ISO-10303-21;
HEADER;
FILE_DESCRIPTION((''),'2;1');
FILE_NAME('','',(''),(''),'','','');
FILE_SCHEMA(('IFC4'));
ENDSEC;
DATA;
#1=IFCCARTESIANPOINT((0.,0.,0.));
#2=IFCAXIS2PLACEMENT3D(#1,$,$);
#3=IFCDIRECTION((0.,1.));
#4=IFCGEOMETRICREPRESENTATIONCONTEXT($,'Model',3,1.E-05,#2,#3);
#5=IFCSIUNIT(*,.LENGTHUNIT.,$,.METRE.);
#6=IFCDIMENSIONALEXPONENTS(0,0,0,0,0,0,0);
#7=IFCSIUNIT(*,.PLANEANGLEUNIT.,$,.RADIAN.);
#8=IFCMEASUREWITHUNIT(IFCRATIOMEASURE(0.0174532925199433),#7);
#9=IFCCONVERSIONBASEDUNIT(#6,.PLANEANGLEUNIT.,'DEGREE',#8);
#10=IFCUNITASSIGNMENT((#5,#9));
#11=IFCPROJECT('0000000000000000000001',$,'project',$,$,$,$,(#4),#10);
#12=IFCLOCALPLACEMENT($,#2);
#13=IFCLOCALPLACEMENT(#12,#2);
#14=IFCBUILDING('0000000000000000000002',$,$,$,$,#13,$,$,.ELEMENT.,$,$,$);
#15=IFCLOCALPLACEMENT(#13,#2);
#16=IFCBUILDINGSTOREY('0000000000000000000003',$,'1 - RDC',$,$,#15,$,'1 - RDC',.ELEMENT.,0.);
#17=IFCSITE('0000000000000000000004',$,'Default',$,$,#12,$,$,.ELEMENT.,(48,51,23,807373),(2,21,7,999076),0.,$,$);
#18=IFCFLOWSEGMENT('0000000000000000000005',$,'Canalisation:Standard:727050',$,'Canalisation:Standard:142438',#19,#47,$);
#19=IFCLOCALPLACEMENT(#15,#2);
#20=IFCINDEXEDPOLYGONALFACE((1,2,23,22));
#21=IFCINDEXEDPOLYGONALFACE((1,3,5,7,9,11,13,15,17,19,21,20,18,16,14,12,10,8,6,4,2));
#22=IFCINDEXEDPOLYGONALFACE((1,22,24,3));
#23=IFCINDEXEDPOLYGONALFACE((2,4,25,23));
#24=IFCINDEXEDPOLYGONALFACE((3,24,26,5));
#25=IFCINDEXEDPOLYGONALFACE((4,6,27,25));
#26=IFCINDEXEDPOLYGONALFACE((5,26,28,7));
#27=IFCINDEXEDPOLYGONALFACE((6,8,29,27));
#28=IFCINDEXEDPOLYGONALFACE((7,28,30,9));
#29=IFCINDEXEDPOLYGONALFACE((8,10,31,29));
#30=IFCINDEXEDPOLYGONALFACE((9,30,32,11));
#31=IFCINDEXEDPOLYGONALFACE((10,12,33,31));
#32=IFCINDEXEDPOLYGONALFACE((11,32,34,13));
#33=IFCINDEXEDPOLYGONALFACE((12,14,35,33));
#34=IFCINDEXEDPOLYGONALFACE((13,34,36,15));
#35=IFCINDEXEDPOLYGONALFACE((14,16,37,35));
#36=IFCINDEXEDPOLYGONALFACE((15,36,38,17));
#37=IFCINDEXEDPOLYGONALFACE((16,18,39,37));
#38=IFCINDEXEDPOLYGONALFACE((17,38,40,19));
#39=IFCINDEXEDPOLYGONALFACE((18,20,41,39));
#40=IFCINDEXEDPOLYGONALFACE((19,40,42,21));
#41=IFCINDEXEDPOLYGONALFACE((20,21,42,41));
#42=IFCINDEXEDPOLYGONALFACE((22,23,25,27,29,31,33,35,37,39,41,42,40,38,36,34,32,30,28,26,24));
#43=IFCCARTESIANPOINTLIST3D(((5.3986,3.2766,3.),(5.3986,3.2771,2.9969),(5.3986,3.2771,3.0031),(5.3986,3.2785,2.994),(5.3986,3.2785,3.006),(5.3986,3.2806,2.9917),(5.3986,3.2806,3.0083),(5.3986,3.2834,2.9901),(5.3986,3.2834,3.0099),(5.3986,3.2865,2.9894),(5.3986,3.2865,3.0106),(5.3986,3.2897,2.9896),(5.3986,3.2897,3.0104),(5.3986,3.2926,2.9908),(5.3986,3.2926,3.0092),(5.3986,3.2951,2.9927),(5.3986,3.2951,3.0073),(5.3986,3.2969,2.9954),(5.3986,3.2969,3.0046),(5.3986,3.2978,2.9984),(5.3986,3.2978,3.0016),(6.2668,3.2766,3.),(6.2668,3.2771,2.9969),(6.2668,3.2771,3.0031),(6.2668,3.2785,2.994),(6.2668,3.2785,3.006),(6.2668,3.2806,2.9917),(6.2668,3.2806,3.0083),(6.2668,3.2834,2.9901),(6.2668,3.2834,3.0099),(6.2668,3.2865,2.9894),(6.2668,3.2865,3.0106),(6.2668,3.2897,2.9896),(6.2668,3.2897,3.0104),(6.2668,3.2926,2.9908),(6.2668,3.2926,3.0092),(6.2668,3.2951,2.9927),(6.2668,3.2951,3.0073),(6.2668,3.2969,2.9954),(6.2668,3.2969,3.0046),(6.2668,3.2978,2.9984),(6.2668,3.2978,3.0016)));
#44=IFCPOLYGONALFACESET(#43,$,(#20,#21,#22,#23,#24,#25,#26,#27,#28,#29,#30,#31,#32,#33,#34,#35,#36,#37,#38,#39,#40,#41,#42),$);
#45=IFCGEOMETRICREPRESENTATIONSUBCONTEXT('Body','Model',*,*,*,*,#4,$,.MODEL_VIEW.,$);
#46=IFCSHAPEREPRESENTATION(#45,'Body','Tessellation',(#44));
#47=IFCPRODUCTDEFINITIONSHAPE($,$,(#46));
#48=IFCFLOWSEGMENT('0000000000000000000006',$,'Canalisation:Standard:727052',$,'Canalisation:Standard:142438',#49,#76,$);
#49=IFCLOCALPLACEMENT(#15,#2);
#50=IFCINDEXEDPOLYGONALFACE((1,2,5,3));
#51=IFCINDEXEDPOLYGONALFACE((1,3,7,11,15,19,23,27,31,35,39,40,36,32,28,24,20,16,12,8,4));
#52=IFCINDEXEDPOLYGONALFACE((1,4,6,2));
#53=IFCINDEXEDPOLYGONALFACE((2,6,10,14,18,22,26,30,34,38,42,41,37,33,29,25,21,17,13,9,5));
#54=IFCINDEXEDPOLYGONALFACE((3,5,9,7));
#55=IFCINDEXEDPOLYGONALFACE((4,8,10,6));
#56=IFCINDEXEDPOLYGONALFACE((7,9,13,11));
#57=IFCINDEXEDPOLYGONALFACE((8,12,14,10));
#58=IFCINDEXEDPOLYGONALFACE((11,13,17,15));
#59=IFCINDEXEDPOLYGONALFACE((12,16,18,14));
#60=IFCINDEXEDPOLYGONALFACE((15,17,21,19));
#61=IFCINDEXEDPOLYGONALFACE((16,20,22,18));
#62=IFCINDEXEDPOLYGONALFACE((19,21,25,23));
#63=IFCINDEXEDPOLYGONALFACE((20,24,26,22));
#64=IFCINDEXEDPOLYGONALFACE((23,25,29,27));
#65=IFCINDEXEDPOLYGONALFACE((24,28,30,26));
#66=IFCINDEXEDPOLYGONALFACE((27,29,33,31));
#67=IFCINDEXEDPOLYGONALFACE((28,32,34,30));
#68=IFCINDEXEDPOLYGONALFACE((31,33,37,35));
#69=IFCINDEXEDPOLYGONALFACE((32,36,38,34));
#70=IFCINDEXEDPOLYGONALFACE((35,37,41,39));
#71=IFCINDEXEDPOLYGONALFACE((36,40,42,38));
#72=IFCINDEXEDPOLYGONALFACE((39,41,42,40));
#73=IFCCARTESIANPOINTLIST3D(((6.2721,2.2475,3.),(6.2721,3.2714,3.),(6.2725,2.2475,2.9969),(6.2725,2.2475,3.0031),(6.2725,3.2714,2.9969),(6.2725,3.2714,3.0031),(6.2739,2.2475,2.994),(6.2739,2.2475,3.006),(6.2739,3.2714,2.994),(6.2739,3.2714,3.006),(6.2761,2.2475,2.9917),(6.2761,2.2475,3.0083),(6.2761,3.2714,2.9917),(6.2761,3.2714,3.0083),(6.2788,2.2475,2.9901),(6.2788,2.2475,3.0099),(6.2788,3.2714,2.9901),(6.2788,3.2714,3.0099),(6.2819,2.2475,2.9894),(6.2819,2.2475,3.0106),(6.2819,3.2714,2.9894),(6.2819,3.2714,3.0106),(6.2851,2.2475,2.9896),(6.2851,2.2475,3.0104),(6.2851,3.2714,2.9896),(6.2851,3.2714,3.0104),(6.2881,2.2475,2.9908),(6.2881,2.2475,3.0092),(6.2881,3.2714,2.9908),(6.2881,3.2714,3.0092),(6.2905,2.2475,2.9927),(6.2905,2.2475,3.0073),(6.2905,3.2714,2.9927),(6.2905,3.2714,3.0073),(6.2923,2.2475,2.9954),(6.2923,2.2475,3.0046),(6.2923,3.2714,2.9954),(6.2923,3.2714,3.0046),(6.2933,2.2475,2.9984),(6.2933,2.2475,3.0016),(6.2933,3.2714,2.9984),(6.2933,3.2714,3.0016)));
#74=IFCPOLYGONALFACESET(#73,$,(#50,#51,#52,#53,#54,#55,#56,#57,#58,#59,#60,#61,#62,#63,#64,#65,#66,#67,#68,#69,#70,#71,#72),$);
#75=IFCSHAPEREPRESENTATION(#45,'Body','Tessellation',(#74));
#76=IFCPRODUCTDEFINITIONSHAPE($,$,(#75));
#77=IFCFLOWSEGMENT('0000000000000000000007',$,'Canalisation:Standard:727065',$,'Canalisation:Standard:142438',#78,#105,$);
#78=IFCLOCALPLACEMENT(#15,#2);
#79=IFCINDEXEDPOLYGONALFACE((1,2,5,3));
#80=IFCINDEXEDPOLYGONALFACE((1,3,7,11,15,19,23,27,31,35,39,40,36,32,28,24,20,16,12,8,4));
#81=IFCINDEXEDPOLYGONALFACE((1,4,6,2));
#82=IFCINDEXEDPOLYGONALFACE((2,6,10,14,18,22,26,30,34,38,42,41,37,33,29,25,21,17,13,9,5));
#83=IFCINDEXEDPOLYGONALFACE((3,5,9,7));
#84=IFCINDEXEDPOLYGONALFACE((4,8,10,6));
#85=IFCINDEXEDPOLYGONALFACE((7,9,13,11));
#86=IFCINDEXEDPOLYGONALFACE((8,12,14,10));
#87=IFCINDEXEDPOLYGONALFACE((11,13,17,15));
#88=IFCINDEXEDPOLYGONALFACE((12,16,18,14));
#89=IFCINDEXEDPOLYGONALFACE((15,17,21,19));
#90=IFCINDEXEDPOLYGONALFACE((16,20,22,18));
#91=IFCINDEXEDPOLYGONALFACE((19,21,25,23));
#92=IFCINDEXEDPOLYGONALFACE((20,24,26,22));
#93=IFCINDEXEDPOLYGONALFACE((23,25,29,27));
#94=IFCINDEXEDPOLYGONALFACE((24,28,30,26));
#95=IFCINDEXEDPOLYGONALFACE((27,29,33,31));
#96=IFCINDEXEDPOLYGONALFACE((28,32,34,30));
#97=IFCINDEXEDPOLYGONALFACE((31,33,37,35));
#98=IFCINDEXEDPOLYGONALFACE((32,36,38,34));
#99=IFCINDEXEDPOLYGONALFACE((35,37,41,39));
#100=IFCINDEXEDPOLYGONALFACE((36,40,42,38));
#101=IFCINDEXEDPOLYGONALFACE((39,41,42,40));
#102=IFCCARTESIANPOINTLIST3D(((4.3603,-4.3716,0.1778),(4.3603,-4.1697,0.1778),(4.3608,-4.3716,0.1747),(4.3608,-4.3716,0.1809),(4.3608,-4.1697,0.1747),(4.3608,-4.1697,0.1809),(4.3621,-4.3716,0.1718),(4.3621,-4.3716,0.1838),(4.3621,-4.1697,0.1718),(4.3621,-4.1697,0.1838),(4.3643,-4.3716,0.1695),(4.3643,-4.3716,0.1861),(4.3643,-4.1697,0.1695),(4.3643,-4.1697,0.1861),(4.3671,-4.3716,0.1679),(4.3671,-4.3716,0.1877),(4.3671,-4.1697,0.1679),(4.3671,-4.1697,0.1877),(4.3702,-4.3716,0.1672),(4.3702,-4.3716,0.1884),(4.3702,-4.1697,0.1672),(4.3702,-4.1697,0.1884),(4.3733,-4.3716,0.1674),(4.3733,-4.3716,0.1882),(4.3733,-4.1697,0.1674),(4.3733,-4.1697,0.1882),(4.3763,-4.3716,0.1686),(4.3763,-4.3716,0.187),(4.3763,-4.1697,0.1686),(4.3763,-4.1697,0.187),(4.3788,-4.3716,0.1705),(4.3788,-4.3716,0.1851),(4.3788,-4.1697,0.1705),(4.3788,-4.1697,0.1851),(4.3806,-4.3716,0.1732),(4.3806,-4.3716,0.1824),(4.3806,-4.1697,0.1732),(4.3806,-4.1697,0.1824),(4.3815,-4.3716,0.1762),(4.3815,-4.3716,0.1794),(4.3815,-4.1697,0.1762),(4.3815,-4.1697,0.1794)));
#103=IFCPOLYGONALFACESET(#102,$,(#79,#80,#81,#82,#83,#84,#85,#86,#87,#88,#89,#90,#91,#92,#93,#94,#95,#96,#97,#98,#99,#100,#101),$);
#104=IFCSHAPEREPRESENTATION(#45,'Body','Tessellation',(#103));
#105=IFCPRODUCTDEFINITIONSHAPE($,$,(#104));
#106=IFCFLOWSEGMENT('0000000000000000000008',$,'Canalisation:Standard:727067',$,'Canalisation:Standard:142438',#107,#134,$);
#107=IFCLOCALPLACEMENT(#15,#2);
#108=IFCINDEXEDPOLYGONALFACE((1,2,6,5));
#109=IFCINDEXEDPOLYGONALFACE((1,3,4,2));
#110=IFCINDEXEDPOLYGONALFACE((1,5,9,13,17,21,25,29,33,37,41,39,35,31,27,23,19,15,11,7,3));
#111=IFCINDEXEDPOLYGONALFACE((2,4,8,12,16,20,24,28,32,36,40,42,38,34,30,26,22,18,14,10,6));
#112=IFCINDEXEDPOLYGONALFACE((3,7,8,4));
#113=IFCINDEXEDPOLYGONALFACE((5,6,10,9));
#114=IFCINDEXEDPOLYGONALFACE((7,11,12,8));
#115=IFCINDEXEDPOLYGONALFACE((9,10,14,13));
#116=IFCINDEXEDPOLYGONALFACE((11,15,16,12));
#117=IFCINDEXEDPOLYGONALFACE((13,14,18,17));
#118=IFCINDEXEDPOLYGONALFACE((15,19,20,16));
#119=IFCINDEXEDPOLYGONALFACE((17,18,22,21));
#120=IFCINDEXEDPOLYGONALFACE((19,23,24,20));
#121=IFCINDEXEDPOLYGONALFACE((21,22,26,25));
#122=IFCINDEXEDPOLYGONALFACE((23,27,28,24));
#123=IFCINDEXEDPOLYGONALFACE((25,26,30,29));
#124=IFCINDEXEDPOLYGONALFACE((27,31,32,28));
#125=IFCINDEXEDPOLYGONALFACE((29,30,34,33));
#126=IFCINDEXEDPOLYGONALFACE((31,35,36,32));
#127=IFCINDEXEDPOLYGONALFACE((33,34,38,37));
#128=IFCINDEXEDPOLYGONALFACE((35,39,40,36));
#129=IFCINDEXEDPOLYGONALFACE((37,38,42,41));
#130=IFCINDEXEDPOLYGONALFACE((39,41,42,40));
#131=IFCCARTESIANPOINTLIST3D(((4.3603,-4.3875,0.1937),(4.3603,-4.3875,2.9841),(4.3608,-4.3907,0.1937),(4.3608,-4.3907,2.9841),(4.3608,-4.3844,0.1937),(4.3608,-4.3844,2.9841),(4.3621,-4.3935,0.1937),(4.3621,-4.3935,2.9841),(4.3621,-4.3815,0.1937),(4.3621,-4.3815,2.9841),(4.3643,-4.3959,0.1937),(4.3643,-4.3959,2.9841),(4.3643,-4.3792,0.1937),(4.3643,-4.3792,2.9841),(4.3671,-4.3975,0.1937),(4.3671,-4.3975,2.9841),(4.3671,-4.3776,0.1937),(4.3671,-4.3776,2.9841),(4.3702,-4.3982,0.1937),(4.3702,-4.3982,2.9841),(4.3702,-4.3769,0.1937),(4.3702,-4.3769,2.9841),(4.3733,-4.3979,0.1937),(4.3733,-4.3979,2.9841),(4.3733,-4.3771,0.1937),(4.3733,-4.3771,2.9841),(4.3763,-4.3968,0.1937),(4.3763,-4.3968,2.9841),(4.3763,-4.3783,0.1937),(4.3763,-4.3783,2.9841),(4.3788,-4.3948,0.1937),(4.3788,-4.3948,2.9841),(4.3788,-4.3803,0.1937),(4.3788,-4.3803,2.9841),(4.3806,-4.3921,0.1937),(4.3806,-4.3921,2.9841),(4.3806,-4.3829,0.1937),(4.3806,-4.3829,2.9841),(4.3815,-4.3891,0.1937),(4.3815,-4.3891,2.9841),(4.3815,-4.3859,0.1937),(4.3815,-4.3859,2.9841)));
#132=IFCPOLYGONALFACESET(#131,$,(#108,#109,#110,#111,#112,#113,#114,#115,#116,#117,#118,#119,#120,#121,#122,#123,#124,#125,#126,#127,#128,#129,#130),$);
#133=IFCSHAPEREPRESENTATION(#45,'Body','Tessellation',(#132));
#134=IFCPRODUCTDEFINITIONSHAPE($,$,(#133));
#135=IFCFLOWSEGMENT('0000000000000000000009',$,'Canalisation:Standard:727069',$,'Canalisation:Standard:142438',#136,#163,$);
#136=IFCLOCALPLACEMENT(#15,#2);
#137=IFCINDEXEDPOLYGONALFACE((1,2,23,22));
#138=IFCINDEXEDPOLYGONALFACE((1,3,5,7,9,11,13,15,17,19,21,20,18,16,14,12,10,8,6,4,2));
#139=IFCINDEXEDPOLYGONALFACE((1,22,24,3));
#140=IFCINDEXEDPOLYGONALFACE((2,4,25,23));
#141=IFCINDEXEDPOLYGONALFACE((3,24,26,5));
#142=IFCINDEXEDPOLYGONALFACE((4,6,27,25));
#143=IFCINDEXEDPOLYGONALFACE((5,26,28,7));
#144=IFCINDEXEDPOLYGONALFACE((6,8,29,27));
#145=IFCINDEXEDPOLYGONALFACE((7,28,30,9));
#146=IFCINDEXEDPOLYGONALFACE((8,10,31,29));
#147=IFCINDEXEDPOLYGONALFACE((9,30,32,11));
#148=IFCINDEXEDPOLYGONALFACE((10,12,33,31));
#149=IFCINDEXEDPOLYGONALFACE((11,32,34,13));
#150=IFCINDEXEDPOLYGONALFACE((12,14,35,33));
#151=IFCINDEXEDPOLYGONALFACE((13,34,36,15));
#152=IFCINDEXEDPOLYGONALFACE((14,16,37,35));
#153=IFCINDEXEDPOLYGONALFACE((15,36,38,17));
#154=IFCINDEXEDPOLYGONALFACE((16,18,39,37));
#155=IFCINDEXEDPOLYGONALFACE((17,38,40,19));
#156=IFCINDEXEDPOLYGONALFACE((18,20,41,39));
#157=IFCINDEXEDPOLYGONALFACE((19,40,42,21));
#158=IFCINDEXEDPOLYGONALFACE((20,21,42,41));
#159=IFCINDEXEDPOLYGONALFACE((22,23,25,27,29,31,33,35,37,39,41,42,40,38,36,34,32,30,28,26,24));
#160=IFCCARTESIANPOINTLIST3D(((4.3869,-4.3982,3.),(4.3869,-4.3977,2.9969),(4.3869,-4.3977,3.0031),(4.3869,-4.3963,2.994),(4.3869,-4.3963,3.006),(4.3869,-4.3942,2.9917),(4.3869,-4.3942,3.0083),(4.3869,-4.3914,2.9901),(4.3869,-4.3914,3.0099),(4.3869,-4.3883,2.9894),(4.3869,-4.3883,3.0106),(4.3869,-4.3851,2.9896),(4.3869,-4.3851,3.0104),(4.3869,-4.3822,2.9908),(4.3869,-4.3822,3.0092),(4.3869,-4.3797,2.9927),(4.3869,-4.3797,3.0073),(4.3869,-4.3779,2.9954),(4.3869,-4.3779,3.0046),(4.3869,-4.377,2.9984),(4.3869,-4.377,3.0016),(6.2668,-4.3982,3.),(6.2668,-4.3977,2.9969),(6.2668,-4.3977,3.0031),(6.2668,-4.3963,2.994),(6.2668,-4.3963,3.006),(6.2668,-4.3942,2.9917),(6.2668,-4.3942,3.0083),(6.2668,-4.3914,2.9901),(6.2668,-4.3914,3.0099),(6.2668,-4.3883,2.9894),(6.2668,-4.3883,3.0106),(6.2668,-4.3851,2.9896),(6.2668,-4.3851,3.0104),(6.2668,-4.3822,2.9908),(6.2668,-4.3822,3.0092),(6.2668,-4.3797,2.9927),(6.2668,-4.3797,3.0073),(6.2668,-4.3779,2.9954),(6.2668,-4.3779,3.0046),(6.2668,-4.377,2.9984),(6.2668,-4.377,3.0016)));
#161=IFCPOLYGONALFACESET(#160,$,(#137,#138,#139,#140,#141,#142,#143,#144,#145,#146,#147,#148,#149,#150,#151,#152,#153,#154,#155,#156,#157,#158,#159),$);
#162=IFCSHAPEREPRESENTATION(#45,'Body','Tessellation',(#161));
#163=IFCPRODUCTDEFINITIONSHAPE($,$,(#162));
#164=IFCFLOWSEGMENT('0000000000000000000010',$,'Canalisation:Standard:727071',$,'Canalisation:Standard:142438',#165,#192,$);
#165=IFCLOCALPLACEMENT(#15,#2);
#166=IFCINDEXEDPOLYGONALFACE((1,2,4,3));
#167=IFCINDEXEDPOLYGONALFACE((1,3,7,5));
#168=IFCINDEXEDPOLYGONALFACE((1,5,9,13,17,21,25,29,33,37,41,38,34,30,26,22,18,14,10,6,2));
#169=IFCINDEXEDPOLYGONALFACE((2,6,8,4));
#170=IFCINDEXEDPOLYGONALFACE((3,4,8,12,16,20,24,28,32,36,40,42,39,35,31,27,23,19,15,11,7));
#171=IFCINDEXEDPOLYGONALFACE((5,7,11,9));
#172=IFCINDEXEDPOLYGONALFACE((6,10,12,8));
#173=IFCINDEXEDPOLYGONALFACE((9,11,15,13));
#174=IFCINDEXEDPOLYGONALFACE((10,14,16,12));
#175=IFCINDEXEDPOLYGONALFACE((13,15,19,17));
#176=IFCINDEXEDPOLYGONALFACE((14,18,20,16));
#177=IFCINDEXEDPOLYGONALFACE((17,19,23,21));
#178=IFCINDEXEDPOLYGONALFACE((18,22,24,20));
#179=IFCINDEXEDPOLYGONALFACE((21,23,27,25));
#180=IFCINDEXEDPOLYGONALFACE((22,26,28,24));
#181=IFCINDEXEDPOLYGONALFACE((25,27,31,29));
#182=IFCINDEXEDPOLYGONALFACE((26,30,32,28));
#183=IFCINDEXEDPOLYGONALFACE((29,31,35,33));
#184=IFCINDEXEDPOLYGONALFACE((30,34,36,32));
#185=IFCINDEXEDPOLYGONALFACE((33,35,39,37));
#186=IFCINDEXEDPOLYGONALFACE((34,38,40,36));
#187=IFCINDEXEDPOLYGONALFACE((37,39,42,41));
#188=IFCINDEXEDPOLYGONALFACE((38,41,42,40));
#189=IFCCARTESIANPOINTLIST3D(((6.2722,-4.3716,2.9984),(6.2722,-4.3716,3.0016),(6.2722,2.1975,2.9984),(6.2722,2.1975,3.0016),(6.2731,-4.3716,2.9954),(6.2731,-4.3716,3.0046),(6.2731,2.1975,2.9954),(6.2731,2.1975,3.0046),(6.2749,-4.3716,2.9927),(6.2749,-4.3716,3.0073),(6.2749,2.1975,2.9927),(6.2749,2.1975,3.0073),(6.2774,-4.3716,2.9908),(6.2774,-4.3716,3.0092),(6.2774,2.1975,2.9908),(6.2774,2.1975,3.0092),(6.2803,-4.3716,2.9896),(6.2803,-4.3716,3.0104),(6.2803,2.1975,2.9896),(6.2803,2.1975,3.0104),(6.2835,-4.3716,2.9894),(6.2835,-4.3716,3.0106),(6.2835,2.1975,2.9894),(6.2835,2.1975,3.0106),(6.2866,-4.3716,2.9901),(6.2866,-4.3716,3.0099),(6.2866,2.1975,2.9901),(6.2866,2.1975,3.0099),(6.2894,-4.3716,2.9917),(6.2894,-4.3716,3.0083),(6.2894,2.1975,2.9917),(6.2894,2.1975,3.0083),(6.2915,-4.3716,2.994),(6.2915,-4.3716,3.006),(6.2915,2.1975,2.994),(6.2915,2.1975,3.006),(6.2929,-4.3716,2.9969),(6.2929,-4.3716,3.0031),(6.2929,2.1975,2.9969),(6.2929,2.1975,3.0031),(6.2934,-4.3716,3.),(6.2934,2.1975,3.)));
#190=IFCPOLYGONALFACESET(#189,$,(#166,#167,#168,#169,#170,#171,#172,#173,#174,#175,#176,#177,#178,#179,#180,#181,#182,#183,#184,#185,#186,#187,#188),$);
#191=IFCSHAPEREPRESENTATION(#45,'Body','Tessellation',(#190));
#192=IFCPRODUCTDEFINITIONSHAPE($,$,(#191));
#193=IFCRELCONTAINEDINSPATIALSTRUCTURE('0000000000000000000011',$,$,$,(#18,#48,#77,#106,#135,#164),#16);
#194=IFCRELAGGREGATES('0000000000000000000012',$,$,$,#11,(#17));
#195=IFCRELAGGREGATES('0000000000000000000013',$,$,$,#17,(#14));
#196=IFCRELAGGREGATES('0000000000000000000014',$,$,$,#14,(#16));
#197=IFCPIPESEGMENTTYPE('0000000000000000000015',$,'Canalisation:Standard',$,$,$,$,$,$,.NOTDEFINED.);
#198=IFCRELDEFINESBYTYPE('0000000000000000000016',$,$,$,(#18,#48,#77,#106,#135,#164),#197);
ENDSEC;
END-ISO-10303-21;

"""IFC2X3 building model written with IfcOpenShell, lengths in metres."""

from ifc_helpers import new_model, entity, si_unit, converted_unit, direction, frame, frame_2d, origin, origin_2d_with_axis, place, context, subcontext, project, spatial, circle, extrude, type_object, element, save


model = new_model("IFC2X3")

# Units and contexts
model_context = context("Model", 3, precision=1e-05, world=origin(), true_north=direction((0.0, 1.0)))
body_context = subcontext(model_context, "Body", "Model", "MODEL_VIEW")
ifc_project = project(units=[si_unit("LENGTHUNIT", "METRE"), converted_unit("PLANEANGLEUNIT", "DEGREE", entity("IfcRatioMeasure", 0.0174532925199433), si_unit("PLANEANGLEUNIT", "RADIAN"), dimensions=[0, 0, 0, 0, 0, 0, 0])], contexts=[model_context])

# Site, building, storey
site_placement = place(None, origin())
site = spatial("IfcSite", under=ifc_project, at=site_placement, Name="Default", CompositionType="ELEMENT", RefLatitude=(48, 51, 23, 807373), RefLongitude=(2, 21, 7, 999076), RefElevation=0.0)
building_placement = place(site_placement, origin())
building = spatial("IfcBuilding", under=site, at=building_placement, CompositionType="ELEMENT")
storey_placement = place(building_placement, origin())
storey = spatial("IfcBuildingStorey", under=building, at=storey_placement, Name="1 - RDC", LongName="1 - RDC", CompositionType="ELEMENT", Elevation=0.0)

# Flow segments
pipe_segment_type = type_object("IfcPipeSegmentType", Name="Canalisation:Standard", PredefinedType="NOTDEFINED")
flow_segment_1_placement = place(storey_placement, origin())
element("IfcFlowSegment", 1, at=flow_segment_1_placement, inside=storey, type_object=pipe_segment_type, Name="Canalisation:Standard:727050", ObjectType="Canalisation:Standard:142438", context=body_context, shape_type="SweptSolid", body=[
    extrude(circle(Radius=0.0107, at=origin_2d_with_axis()), frame((5.3986, 3.2873, 3.0), z_axis=(1.0, 0.0, 0.0), x_axis=(0.0, -1.0, 0.0)), (0.0, 0.0, 1.0), 0.8682),
])
flow_segment_2_placement = place(storey_placement, origin())
element("IfcFlowSegment", 2, at=flow_segment_2_placement, inside=storey, type_object=pipe_segment_type, Name="Canalisation:Standard:727052", ObjectType="Canalisation:Standard:142438", context=body_context, shape_type="SweptSolid", body=[
    extrude(circle(Radius=0.0107, at=frame_2d((0.0, 0.0), x_axis=(1.0, 0.0))), frame((6.2827, 2.2475, 3.0), z_axis=(0.0, 1.0, 0.0), x_axis=(-1.0, 0.0, 0.0)), (0.0, 0.0, 1.0), 1.0239),
])
flow_segment_3_placement = place(storey_placement, origin())
element("IfcFlowSegment", 3, at=flow_segment_3_placement, inside=storey, type_object=pipe_segment_type, Name="Canalisation:Standard:727065", ObjectType="Canalisation:Standard:142438", context=body_context, shape_type="SweptSolid", body=[
    extrude(circle(Radius=0.0107, at=frame_2d((0.0, 0.0), x_axis=(1.0, 0.0))), frame((4.371, -4.3716, 0.1778), z_axis=(0.0, 1.0, 0.0), x_axis=(-1.0, 0.0, 0.0)), (0.0, 0.0, 1.0), 0.2019),
])
flow_segment_4_placement = place(storey_placement, origin())
element("IfcFlowSegment", 4, at=flow_segment_4_placement, inside=storey, type_object=pipe_segment_type, Name="Canalisation:Standard:727067", ObjectType="Canalisation:Standard:142438", context=body_context, shape_type="SweptSolid", body=[
    extrude(circle(Radius=0.0107, at=origin_2d_with_axis()), frame((4.371, -4.3875, 0.1937), z_axis=(0.0, 0.0, 1.0), x_axis=(-1.0, 0.0, 0.0)), (0.0, 0.0, 1.0), 2.7904),
])
flow_segment_5_placement = place(storey_placement, origin())
element("IfcFlowSegment", 5, at=flow_segment_5_placement, inside=storey, type_object=pipe_segment_type, Name="Canalisation:Standard:727069", ObjectType="Canalisation:Standard:142438", context=body_context, shape_type="SweptSolid", body=[
    extrude(circle(Radius=0.0107, at=origin_2d_with_axis()), frame((4.3869, -4.3875, 3.0), z_axis=(1.0, 0.0, 0.0), x_axis=(0.0, -1.0, 0.0)), (0.0, 0.0, 1.0), 1.8799),
])
flow_segment_6_placement = place(storey_placement, origin())
element("IfcFlowSegment", 6, at=flow_segment_6_placement, inside=storey, type_object=pipe_segment_type, Name="Canalisation:Standard:727071", ObjectType="Canalisation:Standard:142438", context=body_context, shape_type="SweptSolid", body=[
    extrude(circle(Radius=0.0107, at=origin_2d_with_axis()), frame((6.2827, -4.3716, 3.0), z_axis=(0.0, 1.0, 0.0), x_axis=(1.0, 0.0, 0.0)), (0.0, 0.0, 1.0), 6.5691),
])

save(model, "model.ifc")
